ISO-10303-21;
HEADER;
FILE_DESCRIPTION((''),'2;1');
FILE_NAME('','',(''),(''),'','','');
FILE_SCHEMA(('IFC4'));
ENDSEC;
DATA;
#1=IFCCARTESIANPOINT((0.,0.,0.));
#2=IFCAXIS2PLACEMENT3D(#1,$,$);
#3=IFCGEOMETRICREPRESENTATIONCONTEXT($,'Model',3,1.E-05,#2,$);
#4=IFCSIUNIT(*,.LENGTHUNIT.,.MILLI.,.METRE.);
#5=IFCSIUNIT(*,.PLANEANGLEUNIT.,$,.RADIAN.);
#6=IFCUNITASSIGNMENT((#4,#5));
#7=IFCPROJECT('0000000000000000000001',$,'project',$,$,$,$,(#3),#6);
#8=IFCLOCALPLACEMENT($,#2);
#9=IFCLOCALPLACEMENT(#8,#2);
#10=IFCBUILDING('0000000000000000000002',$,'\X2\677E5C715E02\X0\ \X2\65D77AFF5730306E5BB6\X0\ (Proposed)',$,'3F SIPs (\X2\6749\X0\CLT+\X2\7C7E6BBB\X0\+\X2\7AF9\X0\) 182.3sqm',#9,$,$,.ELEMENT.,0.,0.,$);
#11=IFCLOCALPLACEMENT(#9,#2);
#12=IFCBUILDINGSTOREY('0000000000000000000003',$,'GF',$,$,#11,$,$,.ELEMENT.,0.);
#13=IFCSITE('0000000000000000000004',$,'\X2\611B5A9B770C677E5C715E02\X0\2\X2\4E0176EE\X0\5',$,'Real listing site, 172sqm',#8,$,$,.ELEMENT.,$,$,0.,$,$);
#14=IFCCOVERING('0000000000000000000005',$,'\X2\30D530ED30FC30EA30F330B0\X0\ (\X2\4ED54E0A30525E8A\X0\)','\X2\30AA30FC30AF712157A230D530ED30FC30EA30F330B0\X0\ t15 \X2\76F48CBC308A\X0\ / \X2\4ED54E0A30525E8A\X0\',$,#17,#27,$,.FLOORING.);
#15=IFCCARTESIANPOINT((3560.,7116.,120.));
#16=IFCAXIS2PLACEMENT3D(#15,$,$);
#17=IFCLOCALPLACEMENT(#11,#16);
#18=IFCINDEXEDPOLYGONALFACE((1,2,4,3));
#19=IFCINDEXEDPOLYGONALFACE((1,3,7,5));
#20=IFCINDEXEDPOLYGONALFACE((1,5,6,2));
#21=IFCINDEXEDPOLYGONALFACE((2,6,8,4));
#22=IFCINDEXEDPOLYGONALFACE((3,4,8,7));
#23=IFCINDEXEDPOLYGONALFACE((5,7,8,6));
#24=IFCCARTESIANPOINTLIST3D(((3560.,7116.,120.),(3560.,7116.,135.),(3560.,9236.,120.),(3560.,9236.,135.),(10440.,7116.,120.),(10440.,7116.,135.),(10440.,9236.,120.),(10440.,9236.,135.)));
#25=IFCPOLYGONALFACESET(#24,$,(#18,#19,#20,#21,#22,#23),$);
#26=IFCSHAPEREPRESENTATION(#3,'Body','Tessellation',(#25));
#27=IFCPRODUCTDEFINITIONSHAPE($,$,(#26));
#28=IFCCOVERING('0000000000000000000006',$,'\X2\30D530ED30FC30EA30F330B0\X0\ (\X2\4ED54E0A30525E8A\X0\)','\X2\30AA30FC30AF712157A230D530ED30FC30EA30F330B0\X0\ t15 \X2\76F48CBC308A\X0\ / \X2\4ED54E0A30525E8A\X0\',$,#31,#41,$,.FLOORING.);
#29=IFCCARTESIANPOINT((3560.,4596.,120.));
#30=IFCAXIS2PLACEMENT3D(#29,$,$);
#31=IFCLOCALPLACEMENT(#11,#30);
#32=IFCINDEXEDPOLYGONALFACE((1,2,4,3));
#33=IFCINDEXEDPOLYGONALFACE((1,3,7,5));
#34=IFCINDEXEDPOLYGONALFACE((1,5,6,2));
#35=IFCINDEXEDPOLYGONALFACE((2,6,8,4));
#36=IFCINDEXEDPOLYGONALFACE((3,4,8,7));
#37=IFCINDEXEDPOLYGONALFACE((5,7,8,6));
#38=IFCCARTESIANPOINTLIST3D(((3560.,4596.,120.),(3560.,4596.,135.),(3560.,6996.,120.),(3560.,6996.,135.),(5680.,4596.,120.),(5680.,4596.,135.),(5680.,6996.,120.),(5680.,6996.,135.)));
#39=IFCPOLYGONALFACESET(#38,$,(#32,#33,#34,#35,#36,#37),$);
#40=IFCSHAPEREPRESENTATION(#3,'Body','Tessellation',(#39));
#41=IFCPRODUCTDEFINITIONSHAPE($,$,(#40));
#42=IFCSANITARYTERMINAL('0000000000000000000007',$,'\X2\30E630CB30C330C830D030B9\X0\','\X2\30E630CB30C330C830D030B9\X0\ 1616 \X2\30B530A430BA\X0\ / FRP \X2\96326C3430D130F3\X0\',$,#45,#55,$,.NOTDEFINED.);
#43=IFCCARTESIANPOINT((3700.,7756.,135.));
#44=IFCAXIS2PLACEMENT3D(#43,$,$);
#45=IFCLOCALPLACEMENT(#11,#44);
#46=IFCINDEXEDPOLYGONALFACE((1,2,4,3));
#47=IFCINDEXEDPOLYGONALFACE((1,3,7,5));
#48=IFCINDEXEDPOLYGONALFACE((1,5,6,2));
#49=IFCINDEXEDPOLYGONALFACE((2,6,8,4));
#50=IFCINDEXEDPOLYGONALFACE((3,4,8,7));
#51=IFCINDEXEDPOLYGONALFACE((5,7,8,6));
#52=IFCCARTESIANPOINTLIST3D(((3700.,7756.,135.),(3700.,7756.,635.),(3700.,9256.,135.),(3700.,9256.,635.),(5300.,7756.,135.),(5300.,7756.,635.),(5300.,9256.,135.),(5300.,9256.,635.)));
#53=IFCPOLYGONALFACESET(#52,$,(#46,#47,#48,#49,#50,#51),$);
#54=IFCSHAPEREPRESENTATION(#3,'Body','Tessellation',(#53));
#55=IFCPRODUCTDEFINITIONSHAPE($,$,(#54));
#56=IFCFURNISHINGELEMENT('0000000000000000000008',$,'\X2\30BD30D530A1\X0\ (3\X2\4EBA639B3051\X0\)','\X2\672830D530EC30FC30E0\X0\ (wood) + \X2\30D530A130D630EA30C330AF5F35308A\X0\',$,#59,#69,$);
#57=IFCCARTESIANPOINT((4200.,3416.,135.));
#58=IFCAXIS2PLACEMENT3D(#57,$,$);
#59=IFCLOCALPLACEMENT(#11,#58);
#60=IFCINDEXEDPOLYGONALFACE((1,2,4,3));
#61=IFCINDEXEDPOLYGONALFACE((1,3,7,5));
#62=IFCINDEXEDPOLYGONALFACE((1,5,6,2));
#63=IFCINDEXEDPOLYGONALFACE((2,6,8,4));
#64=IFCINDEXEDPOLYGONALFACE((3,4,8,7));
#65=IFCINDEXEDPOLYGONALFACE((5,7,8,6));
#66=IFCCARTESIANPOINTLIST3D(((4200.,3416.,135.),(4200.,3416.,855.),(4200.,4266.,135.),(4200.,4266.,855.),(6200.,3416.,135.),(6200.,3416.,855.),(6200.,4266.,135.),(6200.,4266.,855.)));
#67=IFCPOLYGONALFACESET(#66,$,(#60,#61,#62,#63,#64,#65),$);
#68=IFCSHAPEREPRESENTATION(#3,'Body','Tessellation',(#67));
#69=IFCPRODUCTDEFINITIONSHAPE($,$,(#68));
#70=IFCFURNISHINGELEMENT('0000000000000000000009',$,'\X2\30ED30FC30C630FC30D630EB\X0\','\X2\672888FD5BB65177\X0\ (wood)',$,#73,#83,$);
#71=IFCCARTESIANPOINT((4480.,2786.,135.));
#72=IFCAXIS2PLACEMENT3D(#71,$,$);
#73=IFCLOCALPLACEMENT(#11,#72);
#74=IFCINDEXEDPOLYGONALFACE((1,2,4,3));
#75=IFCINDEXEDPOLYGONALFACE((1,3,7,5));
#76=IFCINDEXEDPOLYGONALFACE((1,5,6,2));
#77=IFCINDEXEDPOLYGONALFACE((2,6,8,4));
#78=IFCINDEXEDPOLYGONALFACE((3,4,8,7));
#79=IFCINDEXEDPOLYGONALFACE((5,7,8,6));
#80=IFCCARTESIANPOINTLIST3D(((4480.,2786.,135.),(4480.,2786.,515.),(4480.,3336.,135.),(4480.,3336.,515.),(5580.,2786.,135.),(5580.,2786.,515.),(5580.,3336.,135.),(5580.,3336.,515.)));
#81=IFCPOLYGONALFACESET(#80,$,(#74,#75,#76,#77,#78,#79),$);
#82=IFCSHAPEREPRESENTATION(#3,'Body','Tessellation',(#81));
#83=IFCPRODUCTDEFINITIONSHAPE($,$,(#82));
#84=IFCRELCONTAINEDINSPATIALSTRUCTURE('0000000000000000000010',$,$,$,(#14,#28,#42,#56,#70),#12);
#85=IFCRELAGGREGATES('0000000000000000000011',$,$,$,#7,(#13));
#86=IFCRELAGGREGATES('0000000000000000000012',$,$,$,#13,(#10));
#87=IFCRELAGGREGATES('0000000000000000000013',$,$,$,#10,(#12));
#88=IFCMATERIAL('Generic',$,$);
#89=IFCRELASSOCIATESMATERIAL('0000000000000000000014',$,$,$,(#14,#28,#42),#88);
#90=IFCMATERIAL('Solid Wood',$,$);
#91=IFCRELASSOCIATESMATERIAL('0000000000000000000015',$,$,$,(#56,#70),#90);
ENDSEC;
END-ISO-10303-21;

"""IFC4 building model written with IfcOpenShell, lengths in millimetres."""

from ifc_helpers import new_model, si_unit, frame, frame_2d, origin, place, context, project, spatial, rectangle, extrude, material, element, save


model = new_model("IFC4")

# Units and contexts
model_context = context("Model", 3, precision=1e-05, world=origin())
ifc_project = project(units=[si_unit("LENGTHUNIT", "METRE", prefix="MILLI"), si_unit("PLANEANGLEUNIT", "RADIAN")], contexts=[model_context])

# Site, building, storey
site_placement = place(None, origin())
site = spatial("IfcSite", under=ifc_project, at=site_placement, Name="愛媛県松山市2丁目5", ObjectType="Real listing site, 172sqm", CompositionType="ELEMENT", RefElevation=0.0)
building_placement = place(site_placement, origin())
building = spatial("IfcBuilding", under=site, at=building_placement, Name="松山市 旗竿地の家 (Proposed)", ObjectType="3F SIPs (杉CLT+籾殻+竹) 182.3sqm", CompositionType="ELEMENT", ElevationOfRefHeight=0.0, ElevationOfTerrain=0.0)
storey_placement = place(building_placement, origin())
storey = spatial("IfcBuildingStorey", under=building, at=storey_placement, Name="GF", CompositionType="ELEMENT", Elevation=0.0)

# Shared definitions
ifc_material_1 = material(Name="Solid Wood")

# Coverings
ifc_material_2 = material(Name="Generic")
covering_1_placement = place(storey_placement, frame((3560.0, 7116.0, 120.0)))
element("IfcCovering", 1, at=covering_1_placement, inside=storey, material=ifc_material_2, Name="フローリング (仕上げ床)", Description="オーク無垢フローリング t15 直貼り / 仕上げ床", PredefinedType="FLOORING", context=model_context, shape_type="SweptSolid", body=[
    extrude(rectangle(XDim=6880.0, YDim=2120.0, at=frame_2d((3440.0, 1060.0))), frame((3560.0, 7116.0, 120.0)), (0.0, 0.0, 1.0), 15.0),
])
covering_2_placement = place(storey_placement, frame((3560.0, 4596.0, 120.0)))
element("IfcCovering", 2, at=covering_2_placement, inside=storey, material=ifc_material_2, Name="フローリング (仕上げ床)", Description="オーク無垢フローリング t15 直貼り / 仕上げ床", PredefinedType="FLOORING", context=model_context, shape_type="SweptSolid", body=[
    extrude(rectangle(XDim=2120.0, YDim=2400.0, at=frame_2d((1060.0, 1200.0))), frame((3560.0, 4596.0, 120.0)), (0.0, 0.0, 1.0), 15.0),
])

# Sanitary terminal
sanitary_terminal_placement = place(storey_placement, frame((3700.0, 7756.0, 135.0)))
element("IfcSanitaryTerminal", 3, at=sanitary_terminal_placement, inside=storey, material=ifc_material_2, Name="ユニットバス", Description="ユニットバス 1616 サイズ / FRP 防水パン", PredefinedType="NOTDEFINED", context=model_context, shape_type="SweptSolid", body=[
    extrude(rectangle(XDim=1600.0, YDim=1500.0, at=frame_2d((800.0, 750.0))), frame((3700.0, 7756.0, 135.0)), (0.0, 0.0, 1.0), 500.0),
])

# Furnishing elements
furnishing_1_placement = place(storey_placement, frame((4200.0, 3416.0, 135.0)))
element("IfcFurnishingElement", 4, at=furnishing_1_placement, inside=storey, material=ifc_material_1, Name="ソファ (3人掛け)", Description="木フレーム (wood) + ファブリック張り", context=model_context, shape_type="SweptSolid", body=[
    extrude(rectangle(XDim=2000.0, YDim=850.0, at=frame_2d((1000.0, 425.0))), frame((4200.0, 3416.0, 135.0)), (0.0, 0.0, 1.0), 720.0),
])
furnishing_2_placement = place(storey_placement, frame((4480.0, 2786.0, 135.0)))
element("IfcFurnishingElement", 5, at=furnishing_2_placement, inside=storey, material=ifc_material_1, Name="ローテーブル", Description="木製家具 (wood)", context=model_context, shape_type="SweptSolid", body=[
    extrude(rectangle(XDim=1100.0, YDim=550.0, at=frame_2d((550.0, 275.0))), frame((4480.0, 2786.0, 135.0)), (0.0, 0.0, 1.0), 380.0),
])

save(model, "model.ifc")
